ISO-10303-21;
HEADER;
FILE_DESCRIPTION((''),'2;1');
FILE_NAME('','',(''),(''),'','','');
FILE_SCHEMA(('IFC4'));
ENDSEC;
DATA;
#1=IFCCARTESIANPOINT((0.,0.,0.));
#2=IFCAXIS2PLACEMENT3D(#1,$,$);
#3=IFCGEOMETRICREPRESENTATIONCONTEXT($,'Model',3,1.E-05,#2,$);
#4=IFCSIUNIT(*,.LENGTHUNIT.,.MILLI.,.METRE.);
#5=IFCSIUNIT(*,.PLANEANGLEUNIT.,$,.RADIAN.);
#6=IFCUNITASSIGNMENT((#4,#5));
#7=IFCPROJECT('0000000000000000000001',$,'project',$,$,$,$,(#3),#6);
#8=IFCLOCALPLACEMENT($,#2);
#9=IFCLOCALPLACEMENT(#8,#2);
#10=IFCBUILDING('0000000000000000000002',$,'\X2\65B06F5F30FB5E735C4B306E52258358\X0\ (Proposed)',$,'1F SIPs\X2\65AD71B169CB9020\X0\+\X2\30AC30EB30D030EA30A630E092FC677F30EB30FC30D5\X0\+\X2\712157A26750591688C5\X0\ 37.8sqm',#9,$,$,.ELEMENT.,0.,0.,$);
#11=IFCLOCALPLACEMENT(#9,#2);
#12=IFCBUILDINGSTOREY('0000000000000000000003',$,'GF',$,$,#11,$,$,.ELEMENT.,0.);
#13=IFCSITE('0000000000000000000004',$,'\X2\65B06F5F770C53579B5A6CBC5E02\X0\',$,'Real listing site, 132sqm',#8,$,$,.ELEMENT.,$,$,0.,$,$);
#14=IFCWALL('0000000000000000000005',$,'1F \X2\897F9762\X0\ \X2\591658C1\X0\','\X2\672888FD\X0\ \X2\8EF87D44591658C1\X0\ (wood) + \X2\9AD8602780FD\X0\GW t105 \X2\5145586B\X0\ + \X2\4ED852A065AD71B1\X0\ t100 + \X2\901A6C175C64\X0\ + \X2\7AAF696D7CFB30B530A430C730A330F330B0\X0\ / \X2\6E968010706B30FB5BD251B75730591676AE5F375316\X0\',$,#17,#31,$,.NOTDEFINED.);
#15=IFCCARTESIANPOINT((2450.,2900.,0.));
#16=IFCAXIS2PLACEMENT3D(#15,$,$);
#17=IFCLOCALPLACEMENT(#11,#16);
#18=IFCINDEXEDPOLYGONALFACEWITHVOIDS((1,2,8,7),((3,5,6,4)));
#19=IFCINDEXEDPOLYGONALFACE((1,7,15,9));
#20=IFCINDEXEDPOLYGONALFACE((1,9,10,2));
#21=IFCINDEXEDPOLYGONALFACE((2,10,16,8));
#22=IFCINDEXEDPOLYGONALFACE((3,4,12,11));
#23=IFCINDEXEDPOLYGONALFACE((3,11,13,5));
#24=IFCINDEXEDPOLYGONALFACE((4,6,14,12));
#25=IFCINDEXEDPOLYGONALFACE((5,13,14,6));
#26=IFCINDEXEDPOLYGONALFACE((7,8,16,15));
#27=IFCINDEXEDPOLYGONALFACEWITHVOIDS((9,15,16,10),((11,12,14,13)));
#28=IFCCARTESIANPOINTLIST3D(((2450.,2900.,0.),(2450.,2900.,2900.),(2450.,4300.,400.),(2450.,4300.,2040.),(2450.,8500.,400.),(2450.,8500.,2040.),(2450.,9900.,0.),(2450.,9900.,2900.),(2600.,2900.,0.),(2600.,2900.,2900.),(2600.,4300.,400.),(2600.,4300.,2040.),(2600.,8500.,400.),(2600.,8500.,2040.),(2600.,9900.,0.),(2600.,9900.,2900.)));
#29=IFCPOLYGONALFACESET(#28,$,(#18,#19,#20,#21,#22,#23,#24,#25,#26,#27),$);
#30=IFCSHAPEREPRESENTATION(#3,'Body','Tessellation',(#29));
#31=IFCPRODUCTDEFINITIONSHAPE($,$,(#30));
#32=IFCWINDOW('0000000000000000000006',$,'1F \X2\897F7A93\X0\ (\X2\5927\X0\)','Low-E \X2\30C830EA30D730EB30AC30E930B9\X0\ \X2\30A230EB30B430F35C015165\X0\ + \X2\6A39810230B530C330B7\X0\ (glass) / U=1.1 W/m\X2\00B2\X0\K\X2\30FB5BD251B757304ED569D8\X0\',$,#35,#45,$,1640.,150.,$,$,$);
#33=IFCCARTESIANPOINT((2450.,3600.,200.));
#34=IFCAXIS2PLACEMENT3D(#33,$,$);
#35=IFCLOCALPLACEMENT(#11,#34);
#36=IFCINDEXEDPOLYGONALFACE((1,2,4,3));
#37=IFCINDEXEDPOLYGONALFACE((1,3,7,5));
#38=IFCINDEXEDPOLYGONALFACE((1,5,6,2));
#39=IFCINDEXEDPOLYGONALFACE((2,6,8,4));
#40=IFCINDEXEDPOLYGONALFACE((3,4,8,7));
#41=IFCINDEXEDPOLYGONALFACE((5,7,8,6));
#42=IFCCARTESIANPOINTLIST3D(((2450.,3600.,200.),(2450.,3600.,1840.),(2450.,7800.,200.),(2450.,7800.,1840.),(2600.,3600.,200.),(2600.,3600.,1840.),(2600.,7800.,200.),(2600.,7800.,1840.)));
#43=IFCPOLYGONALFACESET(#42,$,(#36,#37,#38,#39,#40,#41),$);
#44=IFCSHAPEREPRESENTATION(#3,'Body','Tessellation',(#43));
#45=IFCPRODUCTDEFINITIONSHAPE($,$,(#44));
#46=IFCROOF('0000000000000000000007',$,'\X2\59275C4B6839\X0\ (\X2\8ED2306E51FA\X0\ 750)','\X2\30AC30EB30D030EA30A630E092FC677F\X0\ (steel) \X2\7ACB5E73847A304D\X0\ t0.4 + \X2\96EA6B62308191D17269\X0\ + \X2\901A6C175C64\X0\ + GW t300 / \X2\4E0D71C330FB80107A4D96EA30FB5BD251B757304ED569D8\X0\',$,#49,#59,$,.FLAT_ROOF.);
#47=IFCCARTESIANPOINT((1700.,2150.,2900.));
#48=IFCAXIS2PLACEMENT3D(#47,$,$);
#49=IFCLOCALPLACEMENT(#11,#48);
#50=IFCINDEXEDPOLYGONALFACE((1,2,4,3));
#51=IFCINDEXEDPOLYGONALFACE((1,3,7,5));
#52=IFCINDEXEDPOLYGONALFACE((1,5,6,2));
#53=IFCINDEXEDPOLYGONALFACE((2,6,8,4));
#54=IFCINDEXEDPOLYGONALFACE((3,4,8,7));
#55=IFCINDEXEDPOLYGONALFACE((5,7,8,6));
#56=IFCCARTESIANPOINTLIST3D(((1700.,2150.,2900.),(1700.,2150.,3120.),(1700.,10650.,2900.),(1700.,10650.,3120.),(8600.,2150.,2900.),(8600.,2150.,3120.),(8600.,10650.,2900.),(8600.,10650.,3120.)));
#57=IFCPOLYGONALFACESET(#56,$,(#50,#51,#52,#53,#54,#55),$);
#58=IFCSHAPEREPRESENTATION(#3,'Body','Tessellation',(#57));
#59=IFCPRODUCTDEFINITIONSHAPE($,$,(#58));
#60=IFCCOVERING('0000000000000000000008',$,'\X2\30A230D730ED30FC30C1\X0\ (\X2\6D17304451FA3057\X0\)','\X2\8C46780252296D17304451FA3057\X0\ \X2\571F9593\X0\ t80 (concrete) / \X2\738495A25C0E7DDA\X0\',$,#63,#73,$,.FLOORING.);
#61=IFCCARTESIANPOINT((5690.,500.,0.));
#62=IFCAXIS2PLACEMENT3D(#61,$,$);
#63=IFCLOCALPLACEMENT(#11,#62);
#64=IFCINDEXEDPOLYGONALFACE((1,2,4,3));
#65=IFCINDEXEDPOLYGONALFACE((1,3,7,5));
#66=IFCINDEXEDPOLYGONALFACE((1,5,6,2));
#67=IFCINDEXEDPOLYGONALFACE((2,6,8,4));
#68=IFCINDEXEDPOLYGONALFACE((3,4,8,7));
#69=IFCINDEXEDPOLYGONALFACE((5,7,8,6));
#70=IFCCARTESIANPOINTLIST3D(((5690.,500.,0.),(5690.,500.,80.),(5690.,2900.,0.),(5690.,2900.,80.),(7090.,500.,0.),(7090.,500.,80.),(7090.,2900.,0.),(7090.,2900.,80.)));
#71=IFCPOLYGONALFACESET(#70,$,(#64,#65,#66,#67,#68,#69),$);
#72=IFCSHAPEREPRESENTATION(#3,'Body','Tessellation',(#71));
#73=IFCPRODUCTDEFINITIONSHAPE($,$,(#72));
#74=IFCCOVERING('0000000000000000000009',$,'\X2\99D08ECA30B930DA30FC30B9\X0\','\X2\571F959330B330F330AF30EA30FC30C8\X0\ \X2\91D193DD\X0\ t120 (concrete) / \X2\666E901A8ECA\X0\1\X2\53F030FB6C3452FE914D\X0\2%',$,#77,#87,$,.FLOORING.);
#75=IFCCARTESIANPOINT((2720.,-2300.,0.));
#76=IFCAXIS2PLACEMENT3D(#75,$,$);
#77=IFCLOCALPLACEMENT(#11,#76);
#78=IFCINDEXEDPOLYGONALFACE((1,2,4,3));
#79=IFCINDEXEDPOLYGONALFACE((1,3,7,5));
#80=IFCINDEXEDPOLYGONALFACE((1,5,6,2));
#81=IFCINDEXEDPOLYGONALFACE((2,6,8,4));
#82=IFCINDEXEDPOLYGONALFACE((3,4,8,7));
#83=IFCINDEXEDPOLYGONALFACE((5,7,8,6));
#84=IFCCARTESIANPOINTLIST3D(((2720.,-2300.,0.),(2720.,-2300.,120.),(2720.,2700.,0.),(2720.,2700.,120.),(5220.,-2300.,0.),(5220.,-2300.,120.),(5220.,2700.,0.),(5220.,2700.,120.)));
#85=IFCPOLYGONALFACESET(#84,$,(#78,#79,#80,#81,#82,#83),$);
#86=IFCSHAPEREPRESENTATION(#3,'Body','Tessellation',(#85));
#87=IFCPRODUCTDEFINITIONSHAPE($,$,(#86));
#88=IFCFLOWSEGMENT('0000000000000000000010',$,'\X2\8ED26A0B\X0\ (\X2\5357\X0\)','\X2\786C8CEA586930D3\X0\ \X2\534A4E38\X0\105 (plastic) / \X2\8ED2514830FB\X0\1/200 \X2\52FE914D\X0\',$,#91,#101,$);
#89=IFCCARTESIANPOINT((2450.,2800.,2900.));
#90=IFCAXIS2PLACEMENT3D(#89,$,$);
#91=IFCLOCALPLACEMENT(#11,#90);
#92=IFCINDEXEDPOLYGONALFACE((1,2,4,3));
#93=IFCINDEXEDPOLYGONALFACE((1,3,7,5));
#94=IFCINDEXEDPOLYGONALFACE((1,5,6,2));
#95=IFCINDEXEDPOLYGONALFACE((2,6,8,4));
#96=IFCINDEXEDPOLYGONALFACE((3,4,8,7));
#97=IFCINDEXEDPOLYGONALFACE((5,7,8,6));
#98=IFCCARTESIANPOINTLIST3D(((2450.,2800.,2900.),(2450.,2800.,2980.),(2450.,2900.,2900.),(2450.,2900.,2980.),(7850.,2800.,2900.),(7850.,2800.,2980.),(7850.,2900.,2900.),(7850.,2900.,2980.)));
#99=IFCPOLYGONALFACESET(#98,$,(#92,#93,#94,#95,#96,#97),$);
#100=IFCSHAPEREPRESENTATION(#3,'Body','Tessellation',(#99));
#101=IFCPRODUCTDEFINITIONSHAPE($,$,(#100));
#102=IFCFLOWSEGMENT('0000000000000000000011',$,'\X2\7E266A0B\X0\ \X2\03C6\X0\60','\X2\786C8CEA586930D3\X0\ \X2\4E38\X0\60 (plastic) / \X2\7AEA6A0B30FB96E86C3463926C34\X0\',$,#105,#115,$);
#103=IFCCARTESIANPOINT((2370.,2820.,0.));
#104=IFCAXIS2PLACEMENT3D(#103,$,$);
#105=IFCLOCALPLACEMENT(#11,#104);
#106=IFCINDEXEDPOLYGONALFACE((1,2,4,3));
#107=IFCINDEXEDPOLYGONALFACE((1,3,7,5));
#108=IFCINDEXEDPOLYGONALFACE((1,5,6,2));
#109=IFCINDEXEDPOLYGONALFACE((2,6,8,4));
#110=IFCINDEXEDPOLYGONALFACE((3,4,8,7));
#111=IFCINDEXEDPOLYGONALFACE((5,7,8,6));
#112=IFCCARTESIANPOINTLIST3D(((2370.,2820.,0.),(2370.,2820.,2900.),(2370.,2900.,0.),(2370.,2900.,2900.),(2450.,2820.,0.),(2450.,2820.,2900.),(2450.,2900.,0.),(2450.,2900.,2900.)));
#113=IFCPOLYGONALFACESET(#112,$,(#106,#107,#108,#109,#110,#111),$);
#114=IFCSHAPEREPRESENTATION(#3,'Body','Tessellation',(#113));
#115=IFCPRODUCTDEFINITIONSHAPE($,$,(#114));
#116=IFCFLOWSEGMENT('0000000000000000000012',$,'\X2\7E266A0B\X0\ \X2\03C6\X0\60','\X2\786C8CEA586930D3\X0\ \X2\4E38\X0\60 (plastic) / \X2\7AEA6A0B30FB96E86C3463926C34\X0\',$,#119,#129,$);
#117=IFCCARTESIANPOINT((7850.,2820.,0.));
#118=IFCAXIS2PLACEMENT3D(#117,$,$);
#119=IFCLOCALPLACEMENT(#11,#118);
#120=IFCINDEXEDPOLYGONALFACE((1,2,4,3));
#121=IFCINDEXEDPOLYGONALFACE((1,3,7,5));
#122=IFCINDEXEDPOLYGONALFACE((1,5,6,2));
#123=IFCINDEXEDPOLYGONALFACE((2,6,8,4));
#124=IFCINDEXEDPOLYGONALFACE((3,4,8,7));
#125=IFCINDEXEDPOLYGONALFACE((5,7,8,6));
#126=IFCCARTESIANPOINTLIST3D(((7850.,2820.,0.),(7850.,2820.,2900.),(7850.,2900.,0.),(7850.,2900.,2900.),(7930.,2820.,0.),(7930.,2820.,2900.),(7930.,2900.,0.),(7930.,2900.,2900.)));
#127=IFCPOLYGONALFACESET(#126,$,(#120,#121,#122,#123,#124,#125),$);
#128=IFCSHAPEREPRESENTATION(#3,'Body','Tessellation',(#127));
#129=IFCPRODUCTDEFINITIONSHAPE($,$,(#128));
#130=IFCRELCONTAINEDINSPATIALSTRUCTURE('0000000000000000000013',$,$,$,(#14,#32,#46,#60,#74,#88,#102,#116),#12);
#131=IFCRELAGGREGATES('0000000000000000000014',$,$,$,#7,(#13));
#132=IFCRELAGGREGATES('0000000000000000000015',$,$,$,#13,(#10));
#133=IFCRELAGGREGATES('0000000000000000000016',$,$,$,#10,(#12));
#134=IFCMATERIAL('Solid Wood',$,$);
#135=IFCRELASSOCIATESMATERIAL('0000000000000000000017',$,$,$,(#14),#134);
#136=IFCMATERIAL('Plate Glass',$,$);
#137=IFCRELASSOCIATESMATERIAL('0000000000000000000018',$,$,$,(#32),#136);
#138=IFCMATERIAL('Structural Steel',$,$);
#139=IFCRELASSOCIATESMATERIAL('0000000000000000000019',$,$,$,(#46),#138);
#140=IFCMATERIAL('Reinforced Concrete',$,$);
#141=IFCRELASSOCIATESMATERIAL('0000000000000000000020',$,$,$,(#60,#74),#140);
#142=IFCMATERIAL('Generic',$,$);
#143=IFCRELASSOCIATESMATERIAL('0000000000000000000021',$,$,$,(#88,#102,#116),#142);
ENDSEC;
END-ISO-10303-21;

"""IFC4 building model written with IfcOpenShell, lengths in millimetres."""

from ifc_helpers import new_model, si_unit, frame, frame_2d, origin, place, context, project, spatial, rectangle, extrude, material, element, fill, save


model = new_model("IFC4")

# Units and contexts
model_context = context("Model", 3, precision=1e-05, world=origin())
ifc_project = project(units=[si_unit("LENGTHUNIT", "METRE", prefix="MILLI"), si_unit("PLANEANGLEUNIT", "RADIAN")], contexts=[model_context])

# Site, building, storey
site_placement = place(None, origin())
site = spatial("IfcSite", under=ifc_project, at=site_placement, Name="新潟県南魚沼市", ObjectType="Real listing site, 132sqm", CompositionType="ELEMENT", RefElevation=0.0)
building_placement = place(site_placement, origin())
building = spatial("IfcBuilding", under=site, at=building_placement, Name="新潟・平屋の別荘 (Proposed)", ObjectType="1F SIPs断熱構造+ガルバリウム鋼板ルーフ+無垢材外装 37.8sqm", CompositionType="ELEMENT", ElevationOfRefHeight=0.0, ElevationOfTerrain=0.0)
storey_placement = place(building_placement, origin())
storey = spatial("IfcBuildingStorey", under=building, at=storey_placement, Name="GF", CompositionType="ELEMENT", Elevation=0.0)

# Shared definitions
ifc_material_1 = material(Name="Solid Wood")

# Shared definitions
ifc_material_2 = material(Name="Reinforced Concrete")

# Shared definitions
ifc_material_3 = material(Name="Plate Glass")

# Wall, opening, window
wall_1_placement = place(storey_placement, frame((2450.0, 2900.0, 0.0)))
wall_1 = element("IfcWall", 1, at=wall_1_placement, inside=storey, material=ifc_material_1, Name="1F 西面 外壁", Description="木製 軸組外壁 (wood) + 高性能GW t105 充填 + 付加断熱 t100 + 通気層 + 窯業系サイディング / 準耐火・寒冷地外皮強化", PredefinedType="NOTDEFINED", context=model_context, shape_type="SweptSolid", body=[
    extrude(rectangle(XDim=150.0, YDim=7000.0, at=frame_2d((75.0, 3500.0))), frame((2450.0, 2900.0, 0.0)), (0.0, 0.0, 1.0), 2900.0),
])
opening_1_placement = place(storey_placement, frame((2450.0, 3600.0, 200.0)))
opening_1 = element("IfcOpeningElement", 2, at=opening_1_placement, cuts=wall_1, PredefinedType="NOTDEFINED", context=model_context, shape_type="SweptSolid", body=[
    extrude(rectangle(XDim=150.0, YDim=4200.0, at=frame_2d((75.0, 2100.0))), frame((2450.0, 3600.0, 200.0)), (0.0, 0.0, 1.0), 1640.0),
])
window_1_placement = place(storey_placement, frame((2450.0, 3600.0, 200.0)))
window_1 = element("IfcWindow", 3, at=window_1_placement, inside=storey, material=ifc_material_3, Name="1F 西窓 (大)", Description="Low-E トリプルガラス アルゴン封入 + 樹脂サッシ (glass) / U=1.1 W/m²K・寒冷地仕様", OverallHeight=1640.0, OverallWidth=150.0, context=model_context, shape_type="SweptSolid", body=[
    extrude(rectangle(XDim=150.0, YDim=4200.0, at=frame_2d((75.0, 2100.0))), frame((2450.0, 3600.0, 200.0)), (0.0, 0.0, 1.0), 1640.0),
])
fill(opening_1, window_1)

# Roof
ifc_material_4 = material(Name="Structural Steel")
roof_placement = place(storey_placement, frame((1700.0, 2150.0, 2900.0)))
element("IfcRoof", 4, at=roof_placement, inside=storey, material=ifc_material_4, Name="大屋根 (軒の出 750)", Description="ガルバリウム鋼板 (steel) 立平葺き t0.4 + 雪止め金物 + 通気層 + GW t300 / 不燃・耐積雪・寒冷地仕様", PredefinedType="FLAT_ROOF", context=model_context, shape_type="SweptSolid", body=[
    extrude(rectangle(XDim=6900.0, YDim=8500.0, at=frame_2d((3450.0, 4250.0))), frame((1700.0, 2150.0, 2900.0)), (0.0, 0.0, 1.0), 220.0),
])

# Coverings
covering_1_placement = place(storey_placement, frame((5690.0, 500.0, 0.0)))
element("IfcCovering", 5, at=covering_1_placement, inside=storey, material=ifc_material_2, Name="アプローチ (洗い出し)", Description="豆砂利洗い出し 土間 t80 (concrete) / 玄関導線", PredefinedType="FLOORING", context=model_context, shape_type="SweptSolid", body=[
    extrude(rectangle(XDim=1400.0, YDim=2400.0, at=frame_2d((700.0, 1200.0))), frame((5690.0, 500.0, 0.0)), (0.0, 0.0, 1.0), 80.0),
])
covering_2_placement = place(storey_placement, frame((2720.0, -2300.0, 0.0)))
element("IfcCovering", 6, at=covering_2_placement, inside=storey, material=ifc_material_2, Name="駐車スペース", Description="土間コンクリート 金鏝 t120 (concrete) / 普通車1台・水勾配2%", PredefinedType="FLOORING", context=model_context, shape_type="SweptSolid", body=[
    extrude(rectangle(XDim=2500.0, YDim=5000.0, at=frame_2d((1250.0, 2500.0))), frame((2720.0, -2300.0, 0.0)), (0.0, 0.0, 1.0), 120.0),
])

# Flow segments
ifc_material_5 = material(Name="Generic")
flow_segment_1_placement = place(storey_placement, frame((2450.0, 2800.0, 2900.0)))
element("IfcFlowSegment", 7, at=flow_segment_1_placement, inside=storey, material=ifc_material_5, Name="軒樋 (南)", Description="硬質塩ビ 半丸105 (plastic) / 軒先・1/200 勾配", context=model_context, shape_type="SweptSolid", body=[
    extrude(rectangle(XDim=5400.0, YDim=100.0, at=frame_2d((2700.0, 50.0))), frame((2450.0, 2800.0, 2900.0)), (0.0, 0.0, 1.0), 80.0),
])
flow_segment_2_placement = place(storey_placement, frame((2370.0, 2820.0, 0.0)))
element("IfcFlowSegment", 8, at=flow_segment_2_placement, inside=storey, material=ifc_material_5, Name="縦樋 φ60", Description="硬質塩ビ 丸60 (plastic) / 竪樋・雨水排水", context=model_context, shape_type="SweptSolid", body=[
    extrude(rectangle(XDim=80.0, YDim=80.0, at=frame_2d((40.0, 40.0))), frame((2370.0, 2820.0, 0.0)), (0.0, 0.0, 1.0), 2900.0),
])
flow_segment_3_placement = place(storey_placement, frame((7850.0, 2820.0, 0.0)))
element("IfcFlowSegment", 9, at=flow_segment_3_placement, inside=storey, material=ifc_material_5, Name="縦樋 φ60", Description="硬質塩ビ 丸60 (plastic) / 竪樋・雨水排水", context=model_context, shape_type="SweptSolid", body=[
    extrude(rectangle(XDim=80.0, YDim=80.0, at=frame_2d((40.0, 40.0))), frame((7850.0, 2820.0, 0.0)), (0.0, 0.0, 1.0), 2900.0),
])

save(model, "model.ifc")
